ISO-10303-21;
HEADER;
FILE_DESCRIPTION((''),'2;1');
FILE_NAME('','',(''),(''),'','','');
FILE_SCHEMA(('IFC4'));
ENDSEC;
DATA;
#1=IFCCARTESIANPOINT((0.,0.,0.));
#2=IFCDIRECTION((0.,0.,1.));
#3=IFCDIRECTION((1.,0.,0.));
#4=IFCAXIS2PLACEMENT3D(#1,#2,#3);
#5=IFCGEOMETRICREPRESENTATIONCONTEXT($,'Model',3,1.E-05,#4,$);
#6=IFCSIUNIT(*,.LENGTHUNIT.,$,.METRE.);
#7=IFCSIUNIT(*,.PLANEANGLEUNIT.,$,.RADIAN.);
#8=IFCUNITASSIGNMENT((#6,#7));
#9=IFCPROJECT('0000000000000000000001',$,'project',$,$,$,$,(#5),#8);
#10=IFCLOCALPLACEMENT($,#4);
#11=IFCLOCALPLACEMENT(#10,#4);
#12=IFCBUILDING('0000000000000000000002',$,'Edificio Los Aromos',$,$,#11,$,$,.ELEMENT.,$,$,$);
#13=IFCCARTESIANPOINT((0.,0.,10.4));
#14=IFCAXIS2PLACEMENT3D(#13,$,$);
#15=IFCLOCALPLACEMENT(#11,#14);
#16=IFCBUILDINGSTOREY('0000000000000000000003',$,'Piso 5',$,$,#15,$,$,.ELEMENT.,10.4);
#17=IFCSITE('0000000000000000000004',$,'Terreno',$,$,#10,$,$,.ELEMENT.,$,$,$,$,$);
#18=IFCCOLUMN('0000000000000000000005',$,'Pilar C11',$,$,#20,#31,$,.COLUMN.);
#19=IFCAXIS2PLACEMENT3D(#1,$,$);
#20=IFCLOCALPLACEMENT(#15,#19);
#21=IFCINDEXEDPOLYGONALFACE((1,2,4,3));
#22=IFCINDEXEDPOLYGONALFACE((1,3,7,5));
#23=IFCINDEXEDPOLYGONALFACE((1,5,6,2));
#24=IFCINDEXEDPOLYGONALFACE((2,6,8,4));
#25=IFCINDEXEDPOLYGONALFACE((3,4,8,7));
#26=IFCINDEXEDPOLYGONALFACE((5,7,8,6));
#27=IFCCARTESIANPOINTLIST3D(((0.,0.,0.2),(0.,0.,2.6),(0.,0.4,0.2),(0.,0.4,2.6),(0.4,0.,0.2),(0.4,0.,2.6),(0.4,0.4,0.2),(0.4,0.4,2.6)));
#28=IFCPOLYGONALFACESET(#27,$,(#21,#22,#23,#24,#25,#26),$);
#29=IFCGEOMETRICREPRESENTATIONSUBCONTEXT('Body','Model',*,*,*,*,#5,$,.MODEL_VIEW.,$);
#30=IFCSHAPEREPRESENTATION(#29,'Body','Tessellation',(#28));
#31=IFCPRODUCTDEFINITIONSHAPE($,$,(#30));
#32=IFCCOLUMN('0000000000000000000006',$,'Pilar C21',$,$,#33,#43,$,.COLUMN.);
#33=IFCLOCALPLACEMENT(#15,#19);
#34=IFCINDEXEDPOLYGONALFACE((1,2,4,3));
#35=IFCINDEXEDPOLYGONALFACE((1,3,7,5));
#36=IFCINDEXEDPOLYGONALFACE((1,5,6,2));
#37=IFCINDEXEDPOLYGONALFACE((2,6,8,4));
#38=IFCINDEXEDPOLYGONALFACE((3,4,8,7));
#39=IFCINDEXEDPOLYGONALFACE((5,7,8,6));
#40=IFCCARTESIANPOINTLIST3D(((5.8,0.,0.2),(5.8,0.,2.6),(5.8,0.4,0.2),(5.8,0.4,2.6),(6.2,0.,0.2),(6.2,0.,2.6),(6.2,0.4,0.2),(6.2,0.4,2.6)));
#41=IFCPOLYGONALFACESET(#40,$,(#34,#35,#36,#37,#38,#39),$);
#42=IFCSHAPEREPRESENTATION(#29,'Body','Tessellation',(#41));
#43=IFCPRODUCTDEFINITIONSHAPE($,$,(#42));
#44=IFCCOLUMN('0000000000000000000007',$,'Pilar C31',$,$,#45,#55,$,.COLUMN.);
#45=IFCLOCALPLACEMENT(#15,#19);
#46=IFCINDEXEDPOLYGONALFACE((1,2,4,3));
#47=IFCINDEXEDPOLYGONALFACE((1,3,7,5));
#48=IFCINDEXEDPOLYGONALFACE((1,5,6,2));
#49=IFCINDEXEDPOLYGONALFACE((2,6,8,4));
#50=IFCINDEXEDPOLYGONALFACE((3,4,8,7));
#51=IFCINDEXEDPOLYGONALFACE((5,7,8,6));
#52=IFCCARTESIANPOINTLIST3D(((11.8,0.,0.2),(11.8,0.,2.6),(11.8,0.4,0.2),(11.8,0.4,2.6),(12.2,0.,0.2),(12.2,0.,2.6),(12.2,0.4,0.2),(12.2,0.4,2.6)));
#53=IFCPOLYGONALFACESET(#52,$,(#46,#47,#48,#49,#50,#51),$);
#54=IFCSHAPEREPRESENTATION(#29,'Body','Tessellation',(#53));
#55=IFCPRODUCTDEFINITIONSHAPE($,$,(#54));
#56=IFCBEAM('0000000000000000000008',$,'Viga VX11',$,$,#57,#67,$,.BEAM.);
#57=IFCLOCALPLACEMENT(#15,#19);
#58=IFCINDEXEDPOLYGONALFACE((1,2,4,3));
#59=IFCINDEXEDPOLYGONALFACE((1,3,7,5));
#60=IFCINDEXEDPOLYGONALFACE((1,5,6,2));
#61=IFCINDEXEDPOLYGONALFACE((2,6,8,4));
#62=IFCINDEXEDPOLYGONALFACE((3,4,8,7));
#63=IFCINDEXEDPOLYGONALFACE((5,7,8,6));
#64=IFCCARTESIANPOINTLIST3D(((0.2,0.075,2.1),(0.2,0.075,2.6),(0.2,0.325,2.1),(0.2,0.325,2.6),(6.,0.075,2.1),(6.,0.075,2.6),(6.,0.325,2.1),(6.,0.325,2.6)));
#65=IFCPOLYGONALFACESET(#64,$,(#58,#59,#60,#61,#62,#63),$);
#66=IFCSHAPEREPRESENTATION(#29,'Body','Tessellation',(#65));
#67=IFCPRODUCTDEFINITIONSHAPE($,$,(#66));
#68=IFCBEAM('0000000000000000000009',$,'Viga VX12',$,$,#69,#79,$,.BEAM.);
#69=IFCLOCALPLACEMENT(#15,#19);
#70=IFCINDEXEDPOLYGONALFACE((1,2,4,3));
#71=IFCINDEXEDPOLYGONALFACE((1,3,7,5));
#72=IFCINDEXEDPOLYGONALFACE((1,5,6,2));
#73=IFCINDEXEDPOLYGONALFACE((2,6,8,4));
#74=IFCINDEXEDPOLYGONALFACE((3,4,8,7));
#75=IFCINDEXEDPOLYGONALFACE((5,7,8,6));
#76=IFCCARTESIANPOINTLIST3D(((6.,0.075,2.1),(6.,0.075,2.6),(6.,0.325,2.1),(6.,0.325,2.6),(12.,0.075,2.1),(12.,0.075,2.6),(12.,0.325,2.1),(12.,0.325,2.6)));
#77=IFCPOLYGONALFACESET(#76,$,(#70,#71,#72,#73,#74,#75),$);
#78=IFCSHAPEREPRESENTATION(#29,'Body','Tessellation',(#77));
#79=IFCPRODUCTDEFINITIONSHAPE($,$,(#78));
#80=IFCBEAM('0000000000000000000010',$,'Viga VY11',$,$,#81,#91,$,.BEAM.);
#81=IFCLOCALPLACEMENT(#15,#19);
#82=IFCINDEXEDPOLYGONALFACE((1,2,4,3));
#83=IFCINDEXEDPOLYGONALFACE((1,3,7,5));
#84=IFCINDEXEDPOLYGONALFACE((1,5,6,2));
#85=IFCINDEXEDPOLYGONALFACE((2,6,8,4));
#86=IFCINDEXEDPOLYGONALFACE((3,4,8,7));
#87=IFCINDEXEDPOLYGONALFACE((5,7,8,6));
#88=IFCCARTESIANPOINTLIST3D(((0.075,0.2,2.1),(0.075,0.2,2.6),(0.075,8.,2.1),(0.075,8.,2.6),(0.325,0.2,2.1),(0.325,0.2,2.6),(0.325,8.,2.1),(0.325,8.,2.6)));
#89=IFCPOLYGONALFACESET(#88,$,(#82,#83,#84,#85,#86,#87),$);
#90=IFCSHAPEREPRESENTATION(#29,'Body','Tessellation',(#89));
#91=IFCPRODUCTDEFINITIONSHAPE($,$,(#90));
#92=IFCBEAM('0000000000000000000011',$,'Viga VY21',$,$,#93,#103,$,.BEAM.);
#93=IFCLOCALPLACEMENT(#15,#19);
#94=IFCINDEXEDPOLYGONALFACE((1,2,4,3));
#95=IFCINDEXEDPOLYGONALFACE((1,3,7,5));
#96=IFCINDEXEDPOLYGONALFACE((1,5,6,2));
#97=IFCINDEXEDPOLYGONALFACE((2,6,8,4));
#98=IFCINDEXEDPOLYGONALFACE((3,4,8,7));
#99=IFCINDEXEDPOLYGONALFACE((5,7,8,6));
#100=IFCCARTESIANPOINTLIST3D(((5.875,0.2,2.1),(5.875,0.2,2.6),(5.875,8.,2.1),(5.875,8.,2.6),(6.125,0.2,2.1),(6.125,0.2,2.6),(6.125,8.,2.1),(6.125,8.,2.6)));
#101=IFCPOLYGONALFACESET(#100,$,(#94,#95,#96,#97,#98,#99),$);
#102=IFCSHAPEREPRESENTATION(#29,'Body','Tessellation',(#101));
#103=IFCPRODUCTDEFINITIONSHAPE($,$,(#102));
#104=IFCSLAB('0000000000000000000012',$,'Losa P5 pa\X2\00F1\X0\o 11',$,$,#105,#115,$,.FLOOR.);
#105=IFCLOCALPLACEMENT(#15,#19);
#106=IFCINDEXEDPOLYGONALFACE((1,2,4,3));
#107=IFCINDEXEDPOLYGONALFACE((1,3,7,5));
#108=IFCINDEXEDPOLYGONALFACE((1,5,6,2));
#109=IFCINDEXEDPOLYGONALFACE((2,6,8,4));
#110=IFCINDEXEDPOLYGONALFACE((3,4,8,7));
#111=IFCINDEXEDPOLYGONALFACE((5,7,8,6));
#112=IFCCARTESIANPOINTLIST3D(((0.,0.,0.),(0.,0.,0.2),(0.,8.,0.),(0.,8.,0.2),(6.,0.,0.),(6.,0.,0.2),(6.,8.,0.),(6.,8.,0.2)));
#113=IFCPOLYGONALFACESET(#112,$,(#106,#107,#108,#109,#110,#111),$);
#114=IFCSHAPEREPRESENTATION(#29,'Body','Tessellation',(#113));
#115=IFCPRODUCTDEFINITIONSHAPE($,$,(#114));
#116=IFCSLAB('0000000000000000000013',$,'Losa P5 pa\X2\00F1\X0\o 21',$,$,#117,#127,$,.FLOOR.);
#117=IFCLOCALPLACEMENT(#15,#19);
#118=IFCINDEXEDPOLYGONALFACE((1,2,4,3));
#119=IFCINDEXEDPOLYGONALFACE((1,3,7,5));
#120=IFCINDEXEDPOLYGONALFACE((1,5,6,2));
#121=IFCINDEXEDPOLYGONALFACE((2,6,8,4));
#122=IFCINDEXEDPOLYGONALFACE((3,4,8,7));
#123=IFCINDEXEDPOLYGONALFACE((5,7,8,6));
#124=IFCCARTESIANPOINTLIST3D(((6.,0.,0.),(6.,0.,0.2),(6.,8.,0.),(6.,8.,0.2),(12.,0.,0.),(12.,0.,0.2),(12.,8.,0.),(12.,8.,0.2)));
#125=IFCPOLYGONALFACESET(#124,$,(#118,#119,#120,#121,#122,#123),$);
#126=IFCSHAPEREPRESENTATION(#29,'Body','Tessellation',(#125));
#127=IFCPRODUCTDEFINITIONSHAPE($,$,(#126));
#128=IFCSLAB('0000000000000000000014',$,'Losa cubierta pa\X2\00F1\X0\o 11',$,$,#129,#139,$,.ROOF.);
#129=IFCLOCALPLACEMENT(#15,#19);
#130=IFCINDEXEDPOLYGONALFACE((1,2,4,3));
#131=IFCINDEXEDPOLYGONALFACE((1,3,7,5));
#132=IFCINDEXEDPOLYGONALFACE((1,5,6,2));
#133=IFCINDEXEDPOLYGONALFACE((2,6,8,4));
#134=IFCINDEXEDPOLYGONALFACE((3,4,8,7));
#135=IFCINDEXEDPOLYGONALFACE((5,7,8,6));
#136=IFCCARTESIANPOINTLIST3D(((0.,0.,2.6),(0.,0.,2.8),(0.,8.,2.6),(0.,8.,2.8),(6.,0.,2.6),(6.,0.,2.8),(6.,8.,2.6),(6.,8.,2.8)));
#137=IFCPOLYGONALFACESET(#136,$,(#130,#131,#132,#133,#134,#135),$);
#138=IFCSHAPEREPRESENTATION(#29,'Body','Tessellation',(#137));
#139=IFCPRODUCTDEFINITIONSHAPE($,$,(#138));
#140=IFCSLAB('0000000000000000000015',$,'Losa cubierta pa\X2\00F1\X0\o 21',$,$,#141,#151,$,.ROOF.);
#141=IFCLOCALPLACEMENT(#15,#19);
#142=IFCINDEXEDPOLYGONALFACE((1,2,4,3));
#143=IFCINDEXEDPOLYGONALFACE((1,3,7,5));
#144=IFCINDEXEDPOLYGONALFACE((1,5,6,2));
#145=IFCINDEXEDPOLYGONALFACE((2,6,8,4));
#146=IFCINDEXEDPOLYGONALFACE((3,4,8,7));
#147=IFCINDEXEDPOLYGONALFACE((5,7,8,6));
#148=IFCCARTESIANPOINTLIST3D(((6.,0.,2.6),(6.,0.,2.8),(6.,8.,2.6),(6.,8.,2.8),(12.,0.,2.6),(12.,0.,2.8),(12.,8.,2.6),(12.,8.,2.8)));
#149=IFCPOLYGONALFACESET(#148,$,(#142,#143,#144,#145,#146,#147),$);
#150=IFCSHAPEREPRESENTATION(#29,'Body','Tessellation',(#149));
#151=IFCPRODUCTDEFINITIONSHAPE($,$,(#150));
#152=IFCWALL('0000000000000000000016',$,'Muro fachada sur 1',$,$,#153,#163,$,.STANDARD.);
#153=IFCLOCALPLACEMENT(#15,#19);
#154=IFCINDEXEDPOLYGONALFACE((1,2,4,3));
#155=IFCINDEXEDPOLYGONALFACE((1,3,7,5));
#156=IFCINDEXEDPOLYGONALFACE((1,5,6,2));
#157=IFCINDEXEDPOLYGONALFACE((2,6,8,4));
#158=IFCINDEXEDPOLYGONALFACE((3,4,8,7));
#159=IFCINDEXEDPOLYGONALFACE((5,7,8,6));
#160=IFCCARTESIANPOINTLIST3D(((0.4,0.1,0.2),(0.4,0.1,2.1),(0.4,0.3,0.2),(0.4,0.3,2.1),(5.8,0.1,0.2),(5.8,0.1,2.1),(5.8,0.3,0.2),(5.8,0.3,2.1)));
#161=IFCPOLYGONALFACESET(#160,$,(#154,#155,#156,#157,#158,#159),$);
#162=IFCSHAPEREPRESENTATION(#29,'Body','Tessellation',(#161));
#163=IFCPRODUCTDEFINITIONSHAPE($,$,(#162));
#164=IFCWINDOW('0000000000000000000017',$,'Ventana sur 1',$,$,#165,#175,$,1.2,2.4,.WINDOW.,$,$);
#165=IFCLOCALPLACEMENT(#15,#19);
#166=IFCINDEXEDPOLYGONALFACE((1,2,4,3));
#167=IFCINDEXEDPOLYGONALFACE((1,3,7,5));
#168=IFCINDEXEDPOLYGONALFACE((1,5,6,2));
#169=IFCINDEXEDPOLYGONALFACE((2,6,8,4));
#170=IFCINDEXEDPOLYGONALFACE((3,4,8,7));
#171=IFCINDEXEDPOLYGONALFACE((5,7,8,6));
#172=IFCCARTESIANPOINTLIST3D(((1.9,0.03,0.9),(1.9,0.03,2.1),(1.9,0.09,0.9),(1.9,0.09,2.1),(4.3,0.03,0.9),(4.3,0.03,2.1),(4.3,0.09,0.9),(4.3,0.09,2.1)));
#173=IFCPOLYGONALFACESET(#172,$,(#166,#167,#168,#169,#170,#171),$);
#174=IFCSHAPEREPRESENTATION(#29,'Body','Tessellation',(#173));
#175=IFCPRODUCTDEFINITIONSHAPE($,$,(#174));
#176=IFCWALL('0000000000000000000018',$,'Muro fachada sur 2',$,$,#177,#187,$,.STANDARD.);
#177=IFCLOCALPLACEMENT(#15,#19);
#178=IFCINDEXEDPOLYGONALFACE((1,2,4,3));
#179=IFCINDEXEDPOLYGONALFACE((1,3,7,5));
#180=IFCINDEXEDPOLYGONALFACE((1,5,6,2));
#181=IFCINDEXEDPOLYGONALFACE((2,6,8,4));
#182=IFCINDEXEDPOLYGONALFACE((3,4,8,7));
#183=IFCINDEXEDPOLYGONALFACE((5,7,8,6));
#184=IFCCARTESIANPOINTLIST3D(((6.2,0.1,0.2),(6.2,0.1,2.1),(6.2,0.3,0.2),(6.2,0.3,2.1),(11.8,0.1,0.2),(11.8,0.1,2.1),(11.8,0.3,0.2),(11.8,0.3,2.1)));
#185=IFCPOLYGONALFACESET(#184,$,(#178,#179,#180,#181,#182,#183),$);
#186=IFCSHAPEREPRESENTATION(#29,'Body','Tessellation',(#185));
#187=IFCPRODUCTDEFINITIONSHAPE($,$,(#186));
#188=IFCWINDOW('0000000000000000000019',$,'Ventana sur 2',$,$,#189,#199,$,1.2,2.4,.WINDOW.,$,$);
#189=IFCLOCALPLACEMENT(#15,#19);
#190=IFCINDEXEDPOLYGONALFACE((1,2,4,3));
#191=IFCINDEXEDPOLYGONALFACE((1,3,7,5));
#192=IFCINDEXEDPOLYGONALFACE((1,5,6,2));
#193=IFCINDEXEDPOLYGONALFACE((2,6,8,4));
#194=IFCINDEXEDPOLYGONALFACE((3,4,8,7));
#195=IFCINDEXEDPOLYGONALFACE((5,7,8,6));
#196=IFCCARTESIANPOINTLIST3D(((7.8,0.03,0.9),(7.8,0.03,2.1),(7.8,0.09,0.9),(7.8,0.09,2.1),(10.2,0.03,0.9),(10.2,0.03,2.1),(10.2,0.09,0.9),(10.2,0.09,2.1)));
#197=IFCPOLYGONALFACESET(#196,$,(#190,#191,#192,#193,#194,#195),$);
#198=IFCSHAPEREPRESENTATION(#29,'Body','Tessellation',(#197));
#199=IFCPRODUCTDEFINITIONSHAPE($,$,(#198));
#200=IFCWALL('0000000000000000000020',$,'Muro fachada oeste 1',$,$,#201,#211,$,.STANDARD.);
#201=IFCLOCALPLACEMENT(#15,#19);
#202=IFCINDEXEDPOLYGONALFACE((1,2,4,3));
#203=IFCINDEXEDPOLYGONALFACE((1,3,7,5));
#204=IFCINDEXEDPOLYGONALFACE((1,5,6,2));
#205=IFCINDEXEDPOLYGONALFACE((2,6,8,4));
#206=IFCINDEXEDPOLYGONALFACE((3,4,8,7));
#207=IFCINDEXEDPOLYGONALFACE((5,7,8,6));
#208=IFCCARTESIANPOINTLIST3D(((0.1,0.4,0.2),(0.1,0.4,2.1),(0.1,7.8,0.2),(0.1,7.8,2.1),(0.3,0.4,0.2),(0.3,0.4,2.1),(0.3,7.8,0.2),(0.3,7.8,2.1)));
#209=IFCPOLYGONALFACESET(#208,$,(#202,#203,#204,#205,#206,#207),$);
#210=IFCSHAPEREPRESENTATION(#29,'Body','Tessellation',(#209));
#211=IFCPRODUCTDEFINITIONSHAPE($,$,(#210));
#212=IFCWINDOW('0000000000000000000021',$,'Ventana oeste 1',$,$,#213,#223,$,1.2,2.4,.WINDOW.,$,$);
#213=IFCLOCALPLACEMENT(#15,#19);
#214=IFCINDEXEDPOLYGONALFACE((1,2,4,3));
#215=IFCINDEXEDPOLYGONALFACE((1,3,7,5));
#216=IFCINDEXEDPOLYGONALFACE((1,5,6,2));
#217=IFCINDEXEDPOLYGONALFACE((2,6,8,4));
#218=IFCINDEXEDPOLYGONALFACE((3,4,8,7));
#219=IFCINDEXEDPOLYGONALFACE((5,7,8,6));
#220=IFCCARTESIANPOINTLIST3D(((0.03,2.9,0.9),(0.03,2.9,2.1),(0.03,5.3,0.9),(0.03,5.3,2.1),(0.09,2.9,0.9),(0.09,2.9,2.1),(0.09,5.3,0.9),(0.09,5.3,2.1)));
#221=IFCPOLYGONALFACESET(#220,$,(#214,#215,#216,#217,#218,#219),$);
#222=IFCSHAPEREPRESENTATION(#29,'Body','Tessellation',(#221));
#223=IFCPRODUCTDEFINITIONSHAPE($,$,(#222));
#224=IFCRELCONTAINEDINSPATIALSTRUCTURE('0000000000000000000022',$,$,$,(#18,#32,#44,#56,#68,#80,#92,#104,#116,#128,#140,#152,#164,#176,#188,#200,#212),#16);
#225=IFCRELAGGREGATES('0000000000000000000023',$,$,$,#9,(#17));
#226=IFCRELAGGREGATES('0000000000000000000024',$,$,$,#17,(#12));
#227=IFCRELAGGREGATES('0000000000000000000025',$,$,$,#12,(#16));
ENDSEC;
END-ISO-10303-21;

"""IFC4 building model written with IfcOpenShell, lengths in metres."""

from ifc_helpers import new_model, si_unit, frame, frame_2d, origin_with_axes, place, context, subcontext, project, spatial, rectangle, extrude, element, save


model = new_model("IFC4")

# Units and contexts
model_context = context("Model", 3, precision=1e-05, world=origin_with_axes())
body_context = subcontext(model_context, "Body", "Model", "MODEL_VIEW")
ifc_project = project(units=[si_unit("LENGTHUNIT", "METRE"), si_unit("PLANEANGLEUNIT", "RADIAN")], contexts=[model_context])

# Site, building, storey
site_placement = place(None, origin_with_axes())
site = spatial("IfcSite", under=ifc_project, at=site_placement, Name="Terreno", CompositionType="ELEMENT")
building_placement = place(site_placement, origin_with_axes())
building = spatial("IfcBuilding", under=site, at=building_placement, Name="Edificio Los Aromos", CompositionType="ELEMENT")
storey_placement = place(building_placement, frame((0.0, 0.0, 10.4)))
storey = spatial("IfcBuildingStorey", under=building, at=storey_placement, Name="Piso 5", CompositionType="ELEMENT", Elevation=10.4)

# Columns
for number, where, name in (
    (1, (0.0, 0.0, 0.2), "Pilar C11"),
    (2, (5.8, 0.0, 0.2), "Pilar C21"),
    (3, (11.8, 0.0, 0.2), "Pilar C31"),
):
    element("IfcColumn", number, at=place(storey_placement, frame(where)), inside=storey, Name=name, PredefinedType="COLUMN", context=body_context, shape_type="SweptSolid", body=[
        extrude(rectangle(XDim=0.4, YDim=0.4, at=frame_2d((0.2, 0.2))), origin_with_axes(), (0.0, 0.0, 1.0), 2.4),
    ])

# Beams
beam_1_placement = place(storey_placement, frame((0.2, 0.075, 2.1)))
element("IfcBeam", 4, at=beam_1_placement, inside=storey, Name="Viga VX11", PredefinedType="BEAM", context=body_context, shape_type="SweptSolid", body=[
    extrude(rectangle(XDim=5.8, YDim=0.25, at=frame_2d((2.9, 0.125))), origin_with_axes(), (0.0, 0.0, 1.0), 0.5),
])
beam_2_placement = place(storey_placement, frame((6.0, 0.075, 2.1)))
element("IfcBeam", 5, at=beam_2_placement, inside=storey, Name="Viga VX12", PredefinedType="BEAM", context=body_context, shape_type="SweptSolid", body=[
    extrude(rectangle(XDim=6.0, YDim=0.25, at=frame_2d((3.0, 0.125))), origin_with_axes(), (0.0, 0.0, 1.0), 0.5),
])
for number, where, name in (
    (6, (0.075, 0.2, 2.1), "Viga VY11"),
    (7, (5.875, 0.2, 2.1), "Viga VY21"),
):
    element("IfcBeam", number, at=place(storey_placement, frame(where)), inside=storey, Name=name, PredefinedType="BEAM", context=body_context, shape_type="SweptSolid", body=[
        extrude(rectangle(XDim=0.25, YDim=7.8, at=frame_2d((0.125, 3.9))), origin_with_axes(), (0.0, 0.0, 1.0), 0.5),
    ])

# Slabs
for number, where, name in (
    (8, (0.0, 0.0, 0.0), "Losa P5 paño 11"),
    (9, (6.0, 0.0, 0.0), "Losa P5 paño 21"),
):
    element("IfcSlab", number, at=place(storey_placement, frame(where)), inside=storey, Name=name, PredefinedType="FLOOR", context=body_context, shape_type="SweptSolid", body=[
        extrude(rectangle(XDim=6.0, YDim=8.0, at=frame_2d((3.0, 4.0))), origin_with_axes(), (0.0, 0.0, 1.0), 0.2),
    ])
for number, where, name in (
    (10, (0.0, 0.0, 2.6), "Losa cubierta paño 11"),
    (11, (6.0, 0.0, 2.6), "Losa cubierta paño 21"),
):
    element("IfcSlab", number, at=place(storey_placement, frame(where)), inside=storey, Name=name, PredefinedType="ROOF", context=body_context, shape_type="SweptSolid", body=[
        extrude(rectangle(XDim=6.0, YDim=8.0, at=frame_2d((3.0, 4.0))), origin_with_axes(), (0.0, 0.0, 1.0), 0.2),
    ])

# Wall
wall_1_placement = place(storey_placement, frame((0.4, 0.1, 0.2)))
element("IfcWall", 12, at=wall_1_placement, inside=storey, Name="Muro fachada sur 1", PredefinedType="STANDARD", context=body_context, shape_type="SweptSolid", body=[
    extrude(rectangle(XDim=5.4, YDim=0.2, at=frame_2d((2.7, 0.1))), origin_with_axes(), (0.0, 0.0, 1.0), 1.9),
])

# Window
window_1_placement = place(storey_placement, frame((1.9, 0.03, 0.9)))
element("IfcWindow", 13, at=window_1_placement, inside=storey, Name="Ventana sur 1", OverallHeight=1.2, OverallWidth=2.4, PredefinedType="WINDOW", context=body_context, shape_type="SweptSolid", body=[
    extrude(rectangle(XDim=2.4, YDim=0.06, at=frame_2d((1.2, 0.03))), origin_with_axes(), (0.0, 0.0, 1.0), 1.2),
])

# Wall
wall_2_placement = place(storey_placement, frame((6.2, 0.1, 0.2)))
element("IfcWall", 14, at=wall_2_placement, inside=storey, Name="Muro fachada sur 2", PredefinedType="STANDARD", context=body_context, shape_type="SweptSolid", body=[
    extrude(rectangle(XDim=5.6, YDim=0.2, at=frame_2d((2.8, 0.1))), origin_with_axes(), (0.0, 0.0, 1.0), 1.9),
])

# Window
window_2_placement = place(storey_placement, frame((7.8, 0.03, 0.9)))
element("IfcWindow", 15, at=window_2_placement, inside=storey, Name="Ventana sur 2", OverallHeight=1.2, OverallWidth=2.4, PredefinedType="WINDOW", context=body_context, shape_type="SweptSolid", body=[
    extrude(rectangle(XDim=2.4, YDim=0.06, at=frame_2d((1.2, 0.03))), origin_with_axes(), (0.0, 0.0, 1.0), 1.2),
])

# Wall
wall_3_placement = place(storey_placement, frame((0.1, 0.4, 0.2)))
element("IfcWall", 16, at=wall_3_placement, inside=storey, Name="Muro fachada oeste 1", PredefinedType="STANDARD", context=body_context, shape_type="SweptSolid", body=[
    extrude(rectangle(XDim=0.2, YDim=7.4, at=frame_2d((0.1, 3.7))), origin_with_axes(), (0.0, 0.0, 1.0), 1.9),
])

# Window
window_3_placement = place(storey_placement, frame((0.03, 2.9, 0.9)))
element("IfcWindow", 17, at=window_3_placement, inside=storey, Name="Ventana oeste 1", OverallHeight=1.2, OverallWidth=2.4, PredefinedType="WINDOW", context=body_context, shape_type="SweptSolid", body=[
    extrude(rectangle(XDim=0.06, YDim=2.4, at=frame_2d((0.03, 1.2))), origin_with_axes(), (0.0, 0.0, 1.0), 1.2),
])

save(model, "model.ifc")
